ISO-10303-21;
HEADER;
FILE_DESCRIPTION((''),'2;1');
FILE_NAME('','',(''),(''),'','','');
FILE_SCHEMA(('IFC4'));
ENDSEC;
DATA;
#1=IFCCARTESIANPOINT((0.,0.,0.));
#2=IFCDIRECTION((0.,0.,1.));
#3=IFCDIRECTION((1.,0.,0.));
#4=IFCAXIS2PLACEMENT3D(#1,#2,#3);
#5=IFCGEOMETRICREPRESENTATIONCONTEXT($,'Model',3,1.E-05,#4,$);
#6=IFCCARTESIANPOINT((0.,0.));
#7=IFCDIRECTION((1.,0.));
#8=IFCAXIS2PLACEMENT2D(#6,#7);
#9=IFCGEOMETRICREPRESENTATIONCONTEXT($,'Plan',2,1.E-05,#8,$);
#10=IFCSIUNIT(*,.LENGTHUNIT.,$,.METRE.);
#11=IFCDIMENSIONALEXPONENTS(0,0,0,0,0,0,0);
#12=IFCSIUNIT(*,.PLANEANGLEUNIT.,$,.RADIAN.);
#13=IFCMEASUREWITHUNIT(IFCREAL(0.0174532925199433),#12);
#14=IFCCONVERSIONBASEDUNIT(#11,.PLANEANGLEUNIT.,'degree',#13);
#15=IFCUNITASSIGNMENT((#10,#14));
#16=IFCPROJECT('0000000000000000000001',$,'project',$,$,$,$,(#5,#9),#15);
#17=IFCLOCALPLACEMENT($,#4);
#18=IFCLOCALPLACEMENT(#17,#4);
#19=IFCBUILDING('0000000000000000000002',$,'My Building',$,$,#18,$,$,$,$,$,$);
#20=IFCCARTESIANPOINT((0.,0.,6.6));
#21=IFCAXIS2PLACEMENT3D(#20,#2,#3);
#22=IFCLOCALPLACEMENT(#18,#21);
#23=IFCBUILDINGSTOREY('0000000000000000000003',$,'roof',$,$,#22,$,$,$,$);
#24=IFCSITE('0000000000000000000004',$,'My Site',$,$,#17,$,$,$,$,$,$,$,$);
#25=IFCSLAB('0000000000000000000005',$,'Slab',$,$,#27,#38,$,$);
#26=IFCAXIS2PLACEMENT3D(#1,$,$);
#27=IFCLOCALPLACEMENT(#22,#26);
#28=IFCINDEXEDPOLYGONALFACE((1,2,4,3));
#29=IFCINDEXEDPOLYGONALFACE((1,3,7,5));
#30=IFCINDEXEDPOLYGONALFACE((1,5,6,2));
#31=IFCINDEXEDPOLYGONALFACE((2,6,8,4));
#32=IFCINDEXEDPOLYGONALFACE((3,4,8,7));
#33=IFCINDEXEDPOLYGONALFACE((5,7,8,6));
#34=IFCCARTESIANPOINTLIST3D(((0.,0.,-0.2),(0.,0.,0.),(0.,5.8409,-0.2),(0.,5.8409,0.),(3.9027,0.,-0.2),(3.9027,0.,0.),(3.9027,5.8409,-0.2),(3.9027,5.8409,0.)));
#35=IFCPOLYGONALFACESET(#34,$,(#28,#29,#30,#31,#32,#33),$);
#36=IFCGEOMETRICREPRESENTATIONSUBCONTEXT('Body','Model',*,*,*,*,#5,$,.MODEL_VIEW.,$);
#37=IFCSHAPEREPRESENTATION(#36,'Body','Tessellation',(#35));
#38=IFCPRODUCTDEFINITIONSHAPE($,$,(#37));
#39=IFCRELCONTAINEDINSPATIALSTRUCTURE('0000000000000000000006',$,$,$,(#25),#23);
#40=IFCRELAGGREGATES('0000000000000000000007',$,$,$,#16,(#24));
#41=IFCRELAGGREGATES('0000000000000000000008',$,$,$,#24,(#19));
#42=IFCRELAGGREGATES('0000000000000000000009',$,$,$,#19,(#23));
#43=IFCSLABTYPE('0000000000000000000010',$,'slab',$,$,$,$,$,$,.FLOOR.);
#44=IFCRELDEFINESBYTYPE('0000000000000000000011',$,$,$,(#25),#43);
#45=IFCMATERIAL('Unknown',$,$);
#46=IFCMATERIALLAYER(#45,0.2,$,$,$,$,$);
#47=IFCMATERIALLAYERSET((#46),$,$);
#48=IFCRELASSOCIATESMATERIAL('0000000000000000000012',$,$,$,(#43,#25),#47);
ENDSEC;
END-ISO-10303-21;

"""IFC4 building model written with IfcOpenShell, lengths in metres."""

from ifc_helpers import new_model, entity, si_unit, converted_unit, frame, origin_with_axes, origin_2d_with_axis, place, context, subcontext, project, spatial, line, indexed_curve, outline, extrude, material, layer, layer_set, layer_usage, type_object, element, save


model = new_model("IFC4")

# Units and contexts
model_context = context("Model", 3, precision=1e-05, world=origin_with_axes())
plan_context = context("Plan", 2, precision=1e-05, world=origin_2d_with_axis())
body_context = subcontext(model_context, "Body", "Model", "MODEL_VIEW")
ifc_project = project(units=[si_unit("LENGTHUNIT", "METRE"), converted_unit("PLANEANGLEUNIT", "degree", entity("IfcReal", 0.0174532925199433), si_unit("PLANEANGLEUNIT", "RADIAN"), dimensions=[0, 0, 0, 0, 0, 0, 0])], contexts=[model_context, plan_context])

# Site, building, storey
site_placement = place(None, origin_with_axes())
site = spatial("IfcSite", under=ifc_project, at=site_placement, Name="My Site")
building_placement = place(site_placement, origin_with_axes())
building = spatial("IfcBuilding", under=site, at=building_placement, Name="My Building")
storey_placement = place(building_placement, frame((0.0, 0.0, 6.6), z_axis=(0.0, 0.0, 1.0), x_axis=(1.0, 0.0, 0.0)))
storey = spatial("IfcBuildingStorey", under=building, at=storey_placement, Name="roof")

# Slab
ifc_material = material(Name="Unknown")
ifc_layer = layer(ifc_material, 0.2)
ifc_layer_set = layer_set([ifc_layer])
ifc_layer_usage = layer_usage(ifc_layer_set, "AXIS3", "POSITIVE", 0.0)
slab_type = type_object("IfcSlabType", Name="slab", PredefinedType="FLOOR", material=ifc_layer_set)
slab_placement = place(storey_placement, frame((0.0, 0.0, -0.2), z_axis=(0.0, 0.0, 1.0), x_axis=(1.0, 0.0, 0.0)))
element("IfcSlab", 1, at=slab_placement, inside=storey, type_object=slab_type, material=ifc_layer_usage, Name="Slab", context=body_context, shape_type="SweptSolid", body=[
    extrude(outline(indexed_curve([(0.0, 0.0), (3.9027, 0.0), (3.9027, 5.8409), (0.0, 5.8409)], segments=[line(3, 2), line(2, 1), line(1, 4), line(4, 3)], self_intersect=False)), None, (0.0, 0.0, 1.0), 0.2),
])

save(model, "model.ifc")
